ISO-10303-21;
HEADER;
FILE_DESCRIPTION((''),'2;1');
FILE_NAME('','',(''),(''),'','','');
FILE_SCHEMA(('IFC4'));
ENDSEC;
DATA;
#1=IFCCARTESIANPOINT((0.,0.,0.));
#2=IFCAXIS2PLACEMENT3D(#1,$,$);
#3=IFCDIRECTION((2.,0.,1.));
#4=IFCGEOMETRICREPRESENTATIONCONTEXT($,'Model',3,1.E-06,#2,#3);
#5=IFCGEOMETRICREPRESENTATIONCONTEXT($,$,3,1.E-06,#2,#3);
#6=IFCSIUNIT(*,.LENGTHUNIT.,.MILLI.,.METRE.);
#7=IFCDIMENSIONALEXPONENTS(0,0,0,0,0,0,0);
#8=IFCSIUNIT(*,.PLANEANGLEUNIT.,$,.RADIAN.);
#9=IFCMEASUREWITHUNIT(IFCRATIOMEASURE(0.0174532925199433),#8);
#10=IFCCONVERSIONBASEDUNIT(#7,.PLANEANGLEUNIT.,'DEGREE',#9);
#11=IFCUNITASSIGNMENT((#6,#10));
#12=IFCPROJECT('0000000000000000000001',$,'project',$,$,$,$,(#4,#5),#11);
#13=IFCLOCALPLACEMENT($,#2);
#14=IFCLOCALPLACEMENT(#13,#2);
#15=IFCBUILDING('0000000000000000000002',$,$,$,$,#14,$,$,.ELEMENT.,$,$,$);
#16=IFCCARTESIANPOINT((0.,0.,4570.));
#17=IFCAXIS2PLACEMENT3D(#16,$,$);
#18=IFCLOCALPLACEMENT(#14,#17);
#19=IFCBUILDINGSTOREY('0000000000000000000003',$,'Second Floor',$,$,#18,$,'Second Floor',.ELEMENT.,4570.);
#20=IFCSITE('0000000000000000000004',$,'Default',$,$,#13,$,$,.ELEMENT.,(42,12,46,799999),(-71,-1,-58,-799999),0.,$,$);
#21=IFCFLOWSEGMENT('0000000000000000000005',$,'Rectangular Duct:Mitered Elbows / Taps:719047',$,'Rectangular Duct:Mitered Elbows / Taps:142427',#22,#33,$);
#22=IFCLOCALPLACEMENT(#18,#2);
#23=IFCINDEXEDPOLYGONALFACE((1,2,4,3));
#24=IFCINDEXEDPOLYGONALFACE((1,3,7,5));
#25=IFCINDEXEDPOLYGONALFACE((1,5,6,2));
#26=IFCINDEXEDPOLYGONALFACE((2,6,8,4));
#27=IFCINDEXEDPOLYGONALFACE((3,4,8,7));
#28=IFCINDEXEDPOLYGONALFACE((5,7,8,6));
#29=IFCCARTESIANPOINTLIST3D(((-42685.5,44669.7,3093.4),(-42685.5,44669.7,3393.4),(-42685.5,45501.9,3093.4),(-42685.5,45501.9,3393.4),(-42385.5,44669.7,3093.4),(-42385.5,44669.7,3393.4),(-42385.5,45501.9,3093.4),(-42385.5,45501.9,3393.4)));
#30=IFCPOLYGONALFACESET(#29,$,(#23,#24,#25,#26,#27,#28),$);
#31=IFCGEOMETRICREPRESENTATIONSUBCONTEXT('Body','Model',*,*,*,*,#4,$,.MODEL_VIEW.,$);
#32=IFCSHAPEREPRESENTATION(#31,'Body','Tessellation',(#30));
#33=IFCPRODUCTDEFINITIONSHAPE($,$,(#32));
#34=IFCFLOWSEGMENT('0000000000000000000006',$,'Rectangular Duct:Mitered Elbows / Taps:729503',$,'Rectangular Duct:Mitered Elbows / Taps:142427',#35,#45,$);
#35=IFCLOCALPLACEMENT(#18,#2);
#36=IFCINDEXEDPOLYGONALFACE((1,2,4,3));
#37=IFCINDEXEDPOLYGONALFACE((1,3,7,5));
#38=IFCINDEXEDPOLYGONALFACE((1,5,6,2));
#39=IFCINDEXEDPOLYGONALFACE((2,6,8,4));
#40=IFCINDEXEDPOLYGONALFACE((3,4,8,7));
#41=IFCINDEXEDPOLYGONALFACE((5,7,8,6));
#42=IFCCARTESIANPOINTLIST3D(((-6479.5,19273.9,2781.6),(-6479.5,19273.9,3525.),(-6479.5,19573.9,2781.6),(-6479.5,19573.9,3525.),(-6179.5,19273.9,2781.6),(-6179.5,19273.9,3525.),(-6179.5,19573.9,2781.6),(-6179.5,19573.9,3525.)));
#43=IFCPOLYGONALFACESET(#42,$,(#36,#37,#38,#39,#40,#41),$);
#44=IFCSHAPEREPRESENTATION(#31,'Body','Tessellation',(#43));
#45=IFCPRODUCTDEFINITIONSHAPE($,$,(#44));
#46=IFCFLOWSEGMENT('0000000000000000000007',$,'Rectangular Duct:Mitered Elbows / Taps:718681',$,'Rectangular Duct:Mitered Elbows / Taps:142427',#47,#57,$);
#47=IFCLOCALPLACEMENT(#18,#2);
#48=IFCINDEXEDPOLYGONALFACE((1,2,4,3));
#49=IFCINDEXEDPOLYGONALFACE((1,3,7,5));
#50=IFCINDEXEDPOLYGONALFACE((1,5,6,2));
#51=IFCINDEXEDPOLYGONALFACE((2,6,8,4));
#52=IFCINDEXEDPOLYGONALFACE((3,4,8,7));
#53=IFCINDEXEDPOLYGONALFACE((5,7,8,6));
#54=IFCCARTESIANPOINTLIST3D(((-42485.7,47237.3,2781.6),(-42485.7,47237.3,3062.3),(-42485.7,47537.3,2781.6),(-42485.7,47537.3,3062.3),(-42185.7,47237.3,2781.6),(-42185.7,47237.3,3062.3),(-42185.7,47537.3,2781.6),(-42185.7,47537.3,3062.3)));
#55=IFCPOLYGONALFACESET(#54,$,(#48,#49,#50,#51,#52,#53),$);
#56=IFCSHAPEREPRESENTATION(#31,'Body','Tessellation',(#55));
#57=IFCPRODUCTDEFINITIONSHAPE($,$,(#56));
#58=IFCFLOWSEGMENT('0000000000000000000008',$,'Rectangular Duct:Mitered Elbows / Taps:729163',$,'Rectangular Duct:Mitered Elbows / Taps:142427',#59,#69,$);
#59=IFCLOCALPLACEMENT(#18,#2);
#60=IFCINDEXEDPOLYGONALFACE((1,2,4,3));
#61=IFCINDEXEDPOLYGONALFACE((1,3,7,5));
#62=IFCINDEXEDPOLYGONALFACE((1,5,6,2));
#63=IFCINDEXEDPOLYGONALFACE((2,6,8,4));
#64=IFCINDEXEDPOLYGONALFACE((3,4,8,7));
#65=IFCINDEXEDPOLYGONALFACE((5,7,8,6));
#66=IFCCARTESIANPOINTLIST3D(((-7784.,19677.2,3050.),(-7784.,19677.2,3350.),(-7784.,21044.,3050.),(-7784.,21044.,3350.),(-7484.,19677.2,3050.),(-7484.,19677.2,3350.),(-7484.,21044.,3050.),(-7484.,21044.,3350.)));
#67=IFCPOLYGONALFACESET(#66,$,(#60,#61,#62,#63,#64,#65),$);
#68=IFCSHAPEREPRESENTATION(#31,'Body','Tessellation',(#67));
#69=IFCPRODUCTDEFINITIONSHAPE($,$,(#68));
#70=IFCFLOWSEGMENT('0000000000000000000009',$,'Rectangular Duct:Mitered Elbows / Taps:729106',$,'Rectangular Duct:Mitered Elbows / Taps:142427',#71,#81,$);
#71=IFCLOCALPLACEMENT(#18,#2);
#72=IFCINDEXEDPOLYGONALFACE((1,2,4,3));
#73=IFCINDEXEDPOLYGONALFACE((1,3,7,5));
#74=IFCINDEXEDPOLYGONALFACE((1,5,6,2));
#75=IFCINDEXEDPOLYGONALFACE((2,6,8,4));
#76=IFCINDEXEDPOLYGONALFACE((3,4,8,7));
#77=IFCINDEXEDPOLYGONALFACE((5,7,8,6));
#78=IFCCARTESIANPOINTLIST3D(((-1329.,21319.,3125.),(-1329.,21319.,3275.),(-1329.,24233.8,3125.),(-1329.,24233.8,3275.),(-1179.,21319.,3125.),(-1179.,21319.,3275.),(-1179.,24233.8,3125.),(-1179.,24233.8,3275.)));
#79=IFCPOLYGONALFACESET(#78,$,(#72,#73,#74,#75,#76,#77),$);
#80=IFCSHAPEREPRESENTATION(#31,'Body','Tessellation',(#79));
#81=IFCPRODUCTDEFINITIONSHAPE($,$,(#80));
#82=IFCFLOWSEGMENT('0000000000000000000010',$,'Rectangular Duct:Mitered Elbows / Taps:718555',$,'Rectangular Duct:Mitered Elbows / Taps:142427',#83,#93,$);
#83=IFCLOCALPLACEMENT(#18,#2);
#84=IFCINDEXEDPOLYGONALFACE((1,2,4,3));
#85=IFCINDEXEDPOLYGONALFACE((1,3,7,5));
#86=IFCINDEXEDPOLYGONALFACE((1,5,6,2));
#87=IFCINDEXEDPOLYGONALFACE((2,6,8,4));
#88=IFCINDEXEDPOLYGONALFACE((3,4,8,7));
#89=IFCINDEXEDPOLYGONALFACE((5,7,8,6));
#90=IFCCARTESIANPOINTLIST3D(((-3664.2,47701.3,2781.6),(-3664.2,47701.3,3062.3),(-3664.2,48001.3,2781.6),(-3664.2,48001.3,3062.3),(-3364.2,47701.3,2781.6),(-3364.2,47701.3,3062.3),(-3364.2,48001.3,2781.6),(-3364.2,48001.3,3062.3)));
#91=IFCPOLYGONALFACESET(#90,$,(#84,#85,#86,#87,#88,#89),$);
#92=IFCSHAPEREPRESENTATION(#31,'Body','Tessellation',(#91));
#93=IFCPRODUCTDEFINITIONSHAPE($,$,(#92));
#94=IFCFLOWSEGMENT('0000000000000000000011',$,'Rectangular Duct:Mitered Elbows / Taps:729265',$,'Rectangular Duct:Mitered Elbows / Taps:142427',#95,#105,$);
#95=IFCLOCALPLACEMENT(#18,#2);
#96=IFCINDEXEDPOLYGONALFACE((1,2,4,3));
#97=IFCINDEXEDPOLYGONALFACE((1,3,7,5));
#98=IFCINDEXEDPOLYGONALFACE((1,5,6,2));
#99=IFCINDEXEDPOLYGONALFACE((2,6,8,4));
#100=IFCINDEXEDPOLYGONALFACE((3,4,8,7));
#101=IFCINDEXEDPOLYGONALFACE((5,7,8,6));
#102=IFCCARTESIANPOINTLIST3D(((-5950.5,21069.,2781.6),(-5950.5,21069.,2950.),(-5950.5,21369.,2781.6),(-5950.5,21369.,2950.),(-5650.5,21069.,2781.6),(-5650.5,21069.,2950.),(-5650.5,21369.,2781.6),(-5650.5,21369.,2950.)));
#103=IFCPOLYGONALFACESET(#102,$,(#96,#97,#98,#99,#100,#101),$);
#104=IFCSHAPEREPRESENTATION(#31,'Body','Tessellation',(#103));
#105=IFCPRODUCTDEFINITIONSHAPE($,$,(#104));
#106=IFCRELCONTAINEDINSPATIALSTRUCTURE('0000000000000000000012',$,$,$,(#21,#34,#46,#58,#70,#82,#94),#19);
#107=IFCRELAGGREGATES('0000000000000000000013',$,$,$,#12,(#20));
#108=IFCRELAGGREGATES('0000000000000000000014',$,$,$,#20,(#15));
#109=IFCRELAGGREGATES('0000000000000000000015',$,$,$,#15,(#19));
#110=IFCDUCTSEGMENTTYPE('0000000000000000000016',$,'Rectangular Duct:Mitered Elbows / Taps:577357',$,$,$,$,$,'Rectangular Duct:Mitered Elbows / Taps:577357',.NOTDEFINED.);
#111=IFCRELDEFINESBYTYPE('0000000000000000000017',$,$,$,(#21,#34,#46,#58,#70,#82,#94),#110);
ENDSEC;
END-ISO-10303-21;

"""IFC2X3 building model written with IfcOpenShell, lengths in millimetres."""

from ifc_helpers import new_model, entity, si_unit, converted_unit, direction, frame, frame_2d, origin, origin_2d_with_axis, place, context, subcontext, project, spatial, rectangle, extrude, type_object, element, save


model = new_model("IFC2X3")

# Units and contexts
model_context = context("Model", 3, precision=1e-06, world=origin(), true_north=direction((2.0, 0.0, 1.0)))
context_of_model = context(None, 3, precision=1e-06, world=origin(), true_north=direction((2.0, 0.0, 1.0)))
body_context = subcontext(model_context, "Body", "Model", "MODEL_VIEW")
ifc_project = project(units=[si_unit("LENGTHUNIT", "METRE", prefix="MILLI"), converted_unit("PLANEANGLEUNIT", "DEGREE", entity("IfcRatioMeasure", 0.0174532925199433), si_unit("PLANEANGLEUNIT", "RADIAN"), dimensions=[0, 0, 0, 0, 0, 0, 0])], contexts=[model_context, context_of_model])

# Site, building, storey
site_placement = place(None, origin())
site = spatial("IfcSite", under=ifc_project, at=site_placement, Name="Default", CompositionType="ELEMENT", RefLatitude=(42, 12, 46, 799999), RefLongitude=(-71, -1, -58, -799999), RefElevation=0.0)
building_placement = place(site_placement, origin())
building = spatial("IfcBuilding", under=site, at=building_placement, CompositionType="ELEMENT")
storey_placement = place(building_placement, frame((0.0, 0.0, 4570.0)))
storey = spatial("IfcBuildingStorey", under=building, at=storey_placement, Name="Second Floor", LongName="Second Floor", CompositionType="ELEMENT", Elevation=4570.0)

# Flow segments
duct_segment_type_1 = type_object("IfcDuctSegmentType", Name="Rectangular Duct:Mitered Elbows / Taps:577357", ElementType="Rectangular Duct:Mitered Elbows / Taps:577357", PredefinedType="NOTDEFINED")
flow_segment_1_placement = place(storey_placement, origin())
element("IfcFlowSegment", 1, at=flow_segment_1_placement, inside=storey, type_object=duct_segment_type_1, Name="Rectangular Duct:Mitered Elbows / Taps:719047", ObjectType="Rectangular Duct:Mitered Elbows / Taps:142427", context=body_context, shape_type="SweptSolid", body=[
    extrude(rectangle(XDim=832.2, YDim=300.0, at=frame_2d((0.0, 0.0), x_axis=(1.0, 0.0))), frame((-42535.5, 45085.8, 3093.4), z_axis=(0.0, -0.000004, 1.0), x_axis=(0.0, -1.0, -0.000004)), (0.0, 0.0, 1.0), 300.0),
])
flow_segment_2_placement = place(storey_placement, origin())
element("IfcFlowSegment", 2, at=flow_segment_2_placement, inside=storey, type_object=duct_segment_type_1, Name="Rectangular Duct:Mitered Elbows / Taps:729503", ObjectType="Rectangular Duct:Mitered Elbows / Taps:142427", context=body_context, shape_type="SweptSolid", body=[
    extrude(rectangle(XDim=300.0, YDim=300.0, at=frame_2d((0.0, 0.0), x_axis=(1.0, 0.0))), frame((-6329.5, 19423.9, 2781.6)), (0.0, 0.0, 1.0), 743.4),
])
flow_segment_3_placement = place(storey_placement, origin())
element("IfcFlowSegment", 3, at=flow_segment_3_placement, inside=storey, type_object=duct_segment_type_1, Name="Rectangular Duct:Mitered Elbows / Taps:718681", ObjectType="Rectangular Duct:Mitered Elbows / Taps:142427", context=body_context, shape_type="SweptSolid", body=[
    extrude(rectangle(XDim=300.0, YDim=300.0, at=origin_2d_with_axis()), frame((-42335.7, 47387.3, 2781.6), z_axis=(0.0, 0.0, 1.0), x_axis=(0.0, 1.0, 0.0)), (0.0, 0.0, 1.0), 280.7),
])
flow_segment_4_placement = place(storey_placement, origin())
element("IfcFlowSegment", 4, at=flow_segment_4_placement, inside=storey, type_object=duct_segment_type_1, Name="Rectangular Duct:Mitered Elbows / Taps:729163", ObjectType="Rectangular Duct:Mitered Elbows / Taps:142427", context=body_context, shape_type="SweptSolid", body=[
    extrude(rectangle(XDim=1366.8, YDim=300.0, at=frame_2d((0.0, 0.0), x_axis=(1.0, 0.0))), frame((-7634.0, 20360.6, 3050.0), z_axis=(0.0, 0.0, 1.0), x_axis=(0.0, -1.0, 0.0)), (0.0, 0.0, 1.0), 300.0),
])
flow_segment_5_placement = place(storey_placement, origin())
element("IfcFlowSegment", 5, at=flow_segment_5_placement, inside=storey, type_object=duct_segment_type_1, Name="Rectangular Duct:Mitered Elbows / Taps:729106", ObjectType="Rectangular Duct:Mitered Elbows / Taps:142427", context=body_context, shape_type="SweptSolid", body=[
    extrude(rectangle(XDim=2914.8, YDim=150.0, at=frame_2d((0.0, 0.0), x_axis=(1.0, 0.0))), frame((-1254.0, 22776.4, 3125.0), z_axis=(0.0, 0.0, 1.0), x_axis=(0.0, -1.0, 0.0)), (0.0, 0.0, 1.0), 150.0),
])
flow_segment_6_placement = place(storey_placement, origin())
element("IfcFlowSegment", 6, at=flow_segment_6_placement, inside=storey, type_object=duct_segment_type_1, Name="Rectangular Duct:Mitered Elbows / Taps:718555", ObjectType="Rectangular Duct:Mitered Elbows / Taps:142427", context=body_context, shape_type="SweptSolid", body=[
    extrude(rectangle(XDim=300.0, YDim=300.0, at=origin_2d_with_axis()), frame((-3514.2, 47851.3, 2781.6)), (0.0, 0.0, 1.0), 280.7),
])
flow_segment_7_placement = place(storey_placement, origin())
element("IfcFlowSegment", 7, at=flow_segment_7_placement, inside=storey, type_object=duct_segment_type_1, Name="Rectangular Duct:Mitered Elbows / Taps:729265", ObjectType="Rectangular Duct:Mitered Elbows / Taps:142427", context=body_context, shape_type="SweptSolid", body=[
    extrude(rectangle(XDim=300.0, YDim=300.0, at=frame_2d((0.0, 0.0), x_axis=(1.0, 0.0))), frame((-5800.5, 21219.0, 2781.6), z_axis=(0.0, 0.0, 1.0), x_axis=(-1.0, 0.0, 0.0)), (0.0, 0.0, 1.0), 168.4),
])

save(model, "model.ifc")
